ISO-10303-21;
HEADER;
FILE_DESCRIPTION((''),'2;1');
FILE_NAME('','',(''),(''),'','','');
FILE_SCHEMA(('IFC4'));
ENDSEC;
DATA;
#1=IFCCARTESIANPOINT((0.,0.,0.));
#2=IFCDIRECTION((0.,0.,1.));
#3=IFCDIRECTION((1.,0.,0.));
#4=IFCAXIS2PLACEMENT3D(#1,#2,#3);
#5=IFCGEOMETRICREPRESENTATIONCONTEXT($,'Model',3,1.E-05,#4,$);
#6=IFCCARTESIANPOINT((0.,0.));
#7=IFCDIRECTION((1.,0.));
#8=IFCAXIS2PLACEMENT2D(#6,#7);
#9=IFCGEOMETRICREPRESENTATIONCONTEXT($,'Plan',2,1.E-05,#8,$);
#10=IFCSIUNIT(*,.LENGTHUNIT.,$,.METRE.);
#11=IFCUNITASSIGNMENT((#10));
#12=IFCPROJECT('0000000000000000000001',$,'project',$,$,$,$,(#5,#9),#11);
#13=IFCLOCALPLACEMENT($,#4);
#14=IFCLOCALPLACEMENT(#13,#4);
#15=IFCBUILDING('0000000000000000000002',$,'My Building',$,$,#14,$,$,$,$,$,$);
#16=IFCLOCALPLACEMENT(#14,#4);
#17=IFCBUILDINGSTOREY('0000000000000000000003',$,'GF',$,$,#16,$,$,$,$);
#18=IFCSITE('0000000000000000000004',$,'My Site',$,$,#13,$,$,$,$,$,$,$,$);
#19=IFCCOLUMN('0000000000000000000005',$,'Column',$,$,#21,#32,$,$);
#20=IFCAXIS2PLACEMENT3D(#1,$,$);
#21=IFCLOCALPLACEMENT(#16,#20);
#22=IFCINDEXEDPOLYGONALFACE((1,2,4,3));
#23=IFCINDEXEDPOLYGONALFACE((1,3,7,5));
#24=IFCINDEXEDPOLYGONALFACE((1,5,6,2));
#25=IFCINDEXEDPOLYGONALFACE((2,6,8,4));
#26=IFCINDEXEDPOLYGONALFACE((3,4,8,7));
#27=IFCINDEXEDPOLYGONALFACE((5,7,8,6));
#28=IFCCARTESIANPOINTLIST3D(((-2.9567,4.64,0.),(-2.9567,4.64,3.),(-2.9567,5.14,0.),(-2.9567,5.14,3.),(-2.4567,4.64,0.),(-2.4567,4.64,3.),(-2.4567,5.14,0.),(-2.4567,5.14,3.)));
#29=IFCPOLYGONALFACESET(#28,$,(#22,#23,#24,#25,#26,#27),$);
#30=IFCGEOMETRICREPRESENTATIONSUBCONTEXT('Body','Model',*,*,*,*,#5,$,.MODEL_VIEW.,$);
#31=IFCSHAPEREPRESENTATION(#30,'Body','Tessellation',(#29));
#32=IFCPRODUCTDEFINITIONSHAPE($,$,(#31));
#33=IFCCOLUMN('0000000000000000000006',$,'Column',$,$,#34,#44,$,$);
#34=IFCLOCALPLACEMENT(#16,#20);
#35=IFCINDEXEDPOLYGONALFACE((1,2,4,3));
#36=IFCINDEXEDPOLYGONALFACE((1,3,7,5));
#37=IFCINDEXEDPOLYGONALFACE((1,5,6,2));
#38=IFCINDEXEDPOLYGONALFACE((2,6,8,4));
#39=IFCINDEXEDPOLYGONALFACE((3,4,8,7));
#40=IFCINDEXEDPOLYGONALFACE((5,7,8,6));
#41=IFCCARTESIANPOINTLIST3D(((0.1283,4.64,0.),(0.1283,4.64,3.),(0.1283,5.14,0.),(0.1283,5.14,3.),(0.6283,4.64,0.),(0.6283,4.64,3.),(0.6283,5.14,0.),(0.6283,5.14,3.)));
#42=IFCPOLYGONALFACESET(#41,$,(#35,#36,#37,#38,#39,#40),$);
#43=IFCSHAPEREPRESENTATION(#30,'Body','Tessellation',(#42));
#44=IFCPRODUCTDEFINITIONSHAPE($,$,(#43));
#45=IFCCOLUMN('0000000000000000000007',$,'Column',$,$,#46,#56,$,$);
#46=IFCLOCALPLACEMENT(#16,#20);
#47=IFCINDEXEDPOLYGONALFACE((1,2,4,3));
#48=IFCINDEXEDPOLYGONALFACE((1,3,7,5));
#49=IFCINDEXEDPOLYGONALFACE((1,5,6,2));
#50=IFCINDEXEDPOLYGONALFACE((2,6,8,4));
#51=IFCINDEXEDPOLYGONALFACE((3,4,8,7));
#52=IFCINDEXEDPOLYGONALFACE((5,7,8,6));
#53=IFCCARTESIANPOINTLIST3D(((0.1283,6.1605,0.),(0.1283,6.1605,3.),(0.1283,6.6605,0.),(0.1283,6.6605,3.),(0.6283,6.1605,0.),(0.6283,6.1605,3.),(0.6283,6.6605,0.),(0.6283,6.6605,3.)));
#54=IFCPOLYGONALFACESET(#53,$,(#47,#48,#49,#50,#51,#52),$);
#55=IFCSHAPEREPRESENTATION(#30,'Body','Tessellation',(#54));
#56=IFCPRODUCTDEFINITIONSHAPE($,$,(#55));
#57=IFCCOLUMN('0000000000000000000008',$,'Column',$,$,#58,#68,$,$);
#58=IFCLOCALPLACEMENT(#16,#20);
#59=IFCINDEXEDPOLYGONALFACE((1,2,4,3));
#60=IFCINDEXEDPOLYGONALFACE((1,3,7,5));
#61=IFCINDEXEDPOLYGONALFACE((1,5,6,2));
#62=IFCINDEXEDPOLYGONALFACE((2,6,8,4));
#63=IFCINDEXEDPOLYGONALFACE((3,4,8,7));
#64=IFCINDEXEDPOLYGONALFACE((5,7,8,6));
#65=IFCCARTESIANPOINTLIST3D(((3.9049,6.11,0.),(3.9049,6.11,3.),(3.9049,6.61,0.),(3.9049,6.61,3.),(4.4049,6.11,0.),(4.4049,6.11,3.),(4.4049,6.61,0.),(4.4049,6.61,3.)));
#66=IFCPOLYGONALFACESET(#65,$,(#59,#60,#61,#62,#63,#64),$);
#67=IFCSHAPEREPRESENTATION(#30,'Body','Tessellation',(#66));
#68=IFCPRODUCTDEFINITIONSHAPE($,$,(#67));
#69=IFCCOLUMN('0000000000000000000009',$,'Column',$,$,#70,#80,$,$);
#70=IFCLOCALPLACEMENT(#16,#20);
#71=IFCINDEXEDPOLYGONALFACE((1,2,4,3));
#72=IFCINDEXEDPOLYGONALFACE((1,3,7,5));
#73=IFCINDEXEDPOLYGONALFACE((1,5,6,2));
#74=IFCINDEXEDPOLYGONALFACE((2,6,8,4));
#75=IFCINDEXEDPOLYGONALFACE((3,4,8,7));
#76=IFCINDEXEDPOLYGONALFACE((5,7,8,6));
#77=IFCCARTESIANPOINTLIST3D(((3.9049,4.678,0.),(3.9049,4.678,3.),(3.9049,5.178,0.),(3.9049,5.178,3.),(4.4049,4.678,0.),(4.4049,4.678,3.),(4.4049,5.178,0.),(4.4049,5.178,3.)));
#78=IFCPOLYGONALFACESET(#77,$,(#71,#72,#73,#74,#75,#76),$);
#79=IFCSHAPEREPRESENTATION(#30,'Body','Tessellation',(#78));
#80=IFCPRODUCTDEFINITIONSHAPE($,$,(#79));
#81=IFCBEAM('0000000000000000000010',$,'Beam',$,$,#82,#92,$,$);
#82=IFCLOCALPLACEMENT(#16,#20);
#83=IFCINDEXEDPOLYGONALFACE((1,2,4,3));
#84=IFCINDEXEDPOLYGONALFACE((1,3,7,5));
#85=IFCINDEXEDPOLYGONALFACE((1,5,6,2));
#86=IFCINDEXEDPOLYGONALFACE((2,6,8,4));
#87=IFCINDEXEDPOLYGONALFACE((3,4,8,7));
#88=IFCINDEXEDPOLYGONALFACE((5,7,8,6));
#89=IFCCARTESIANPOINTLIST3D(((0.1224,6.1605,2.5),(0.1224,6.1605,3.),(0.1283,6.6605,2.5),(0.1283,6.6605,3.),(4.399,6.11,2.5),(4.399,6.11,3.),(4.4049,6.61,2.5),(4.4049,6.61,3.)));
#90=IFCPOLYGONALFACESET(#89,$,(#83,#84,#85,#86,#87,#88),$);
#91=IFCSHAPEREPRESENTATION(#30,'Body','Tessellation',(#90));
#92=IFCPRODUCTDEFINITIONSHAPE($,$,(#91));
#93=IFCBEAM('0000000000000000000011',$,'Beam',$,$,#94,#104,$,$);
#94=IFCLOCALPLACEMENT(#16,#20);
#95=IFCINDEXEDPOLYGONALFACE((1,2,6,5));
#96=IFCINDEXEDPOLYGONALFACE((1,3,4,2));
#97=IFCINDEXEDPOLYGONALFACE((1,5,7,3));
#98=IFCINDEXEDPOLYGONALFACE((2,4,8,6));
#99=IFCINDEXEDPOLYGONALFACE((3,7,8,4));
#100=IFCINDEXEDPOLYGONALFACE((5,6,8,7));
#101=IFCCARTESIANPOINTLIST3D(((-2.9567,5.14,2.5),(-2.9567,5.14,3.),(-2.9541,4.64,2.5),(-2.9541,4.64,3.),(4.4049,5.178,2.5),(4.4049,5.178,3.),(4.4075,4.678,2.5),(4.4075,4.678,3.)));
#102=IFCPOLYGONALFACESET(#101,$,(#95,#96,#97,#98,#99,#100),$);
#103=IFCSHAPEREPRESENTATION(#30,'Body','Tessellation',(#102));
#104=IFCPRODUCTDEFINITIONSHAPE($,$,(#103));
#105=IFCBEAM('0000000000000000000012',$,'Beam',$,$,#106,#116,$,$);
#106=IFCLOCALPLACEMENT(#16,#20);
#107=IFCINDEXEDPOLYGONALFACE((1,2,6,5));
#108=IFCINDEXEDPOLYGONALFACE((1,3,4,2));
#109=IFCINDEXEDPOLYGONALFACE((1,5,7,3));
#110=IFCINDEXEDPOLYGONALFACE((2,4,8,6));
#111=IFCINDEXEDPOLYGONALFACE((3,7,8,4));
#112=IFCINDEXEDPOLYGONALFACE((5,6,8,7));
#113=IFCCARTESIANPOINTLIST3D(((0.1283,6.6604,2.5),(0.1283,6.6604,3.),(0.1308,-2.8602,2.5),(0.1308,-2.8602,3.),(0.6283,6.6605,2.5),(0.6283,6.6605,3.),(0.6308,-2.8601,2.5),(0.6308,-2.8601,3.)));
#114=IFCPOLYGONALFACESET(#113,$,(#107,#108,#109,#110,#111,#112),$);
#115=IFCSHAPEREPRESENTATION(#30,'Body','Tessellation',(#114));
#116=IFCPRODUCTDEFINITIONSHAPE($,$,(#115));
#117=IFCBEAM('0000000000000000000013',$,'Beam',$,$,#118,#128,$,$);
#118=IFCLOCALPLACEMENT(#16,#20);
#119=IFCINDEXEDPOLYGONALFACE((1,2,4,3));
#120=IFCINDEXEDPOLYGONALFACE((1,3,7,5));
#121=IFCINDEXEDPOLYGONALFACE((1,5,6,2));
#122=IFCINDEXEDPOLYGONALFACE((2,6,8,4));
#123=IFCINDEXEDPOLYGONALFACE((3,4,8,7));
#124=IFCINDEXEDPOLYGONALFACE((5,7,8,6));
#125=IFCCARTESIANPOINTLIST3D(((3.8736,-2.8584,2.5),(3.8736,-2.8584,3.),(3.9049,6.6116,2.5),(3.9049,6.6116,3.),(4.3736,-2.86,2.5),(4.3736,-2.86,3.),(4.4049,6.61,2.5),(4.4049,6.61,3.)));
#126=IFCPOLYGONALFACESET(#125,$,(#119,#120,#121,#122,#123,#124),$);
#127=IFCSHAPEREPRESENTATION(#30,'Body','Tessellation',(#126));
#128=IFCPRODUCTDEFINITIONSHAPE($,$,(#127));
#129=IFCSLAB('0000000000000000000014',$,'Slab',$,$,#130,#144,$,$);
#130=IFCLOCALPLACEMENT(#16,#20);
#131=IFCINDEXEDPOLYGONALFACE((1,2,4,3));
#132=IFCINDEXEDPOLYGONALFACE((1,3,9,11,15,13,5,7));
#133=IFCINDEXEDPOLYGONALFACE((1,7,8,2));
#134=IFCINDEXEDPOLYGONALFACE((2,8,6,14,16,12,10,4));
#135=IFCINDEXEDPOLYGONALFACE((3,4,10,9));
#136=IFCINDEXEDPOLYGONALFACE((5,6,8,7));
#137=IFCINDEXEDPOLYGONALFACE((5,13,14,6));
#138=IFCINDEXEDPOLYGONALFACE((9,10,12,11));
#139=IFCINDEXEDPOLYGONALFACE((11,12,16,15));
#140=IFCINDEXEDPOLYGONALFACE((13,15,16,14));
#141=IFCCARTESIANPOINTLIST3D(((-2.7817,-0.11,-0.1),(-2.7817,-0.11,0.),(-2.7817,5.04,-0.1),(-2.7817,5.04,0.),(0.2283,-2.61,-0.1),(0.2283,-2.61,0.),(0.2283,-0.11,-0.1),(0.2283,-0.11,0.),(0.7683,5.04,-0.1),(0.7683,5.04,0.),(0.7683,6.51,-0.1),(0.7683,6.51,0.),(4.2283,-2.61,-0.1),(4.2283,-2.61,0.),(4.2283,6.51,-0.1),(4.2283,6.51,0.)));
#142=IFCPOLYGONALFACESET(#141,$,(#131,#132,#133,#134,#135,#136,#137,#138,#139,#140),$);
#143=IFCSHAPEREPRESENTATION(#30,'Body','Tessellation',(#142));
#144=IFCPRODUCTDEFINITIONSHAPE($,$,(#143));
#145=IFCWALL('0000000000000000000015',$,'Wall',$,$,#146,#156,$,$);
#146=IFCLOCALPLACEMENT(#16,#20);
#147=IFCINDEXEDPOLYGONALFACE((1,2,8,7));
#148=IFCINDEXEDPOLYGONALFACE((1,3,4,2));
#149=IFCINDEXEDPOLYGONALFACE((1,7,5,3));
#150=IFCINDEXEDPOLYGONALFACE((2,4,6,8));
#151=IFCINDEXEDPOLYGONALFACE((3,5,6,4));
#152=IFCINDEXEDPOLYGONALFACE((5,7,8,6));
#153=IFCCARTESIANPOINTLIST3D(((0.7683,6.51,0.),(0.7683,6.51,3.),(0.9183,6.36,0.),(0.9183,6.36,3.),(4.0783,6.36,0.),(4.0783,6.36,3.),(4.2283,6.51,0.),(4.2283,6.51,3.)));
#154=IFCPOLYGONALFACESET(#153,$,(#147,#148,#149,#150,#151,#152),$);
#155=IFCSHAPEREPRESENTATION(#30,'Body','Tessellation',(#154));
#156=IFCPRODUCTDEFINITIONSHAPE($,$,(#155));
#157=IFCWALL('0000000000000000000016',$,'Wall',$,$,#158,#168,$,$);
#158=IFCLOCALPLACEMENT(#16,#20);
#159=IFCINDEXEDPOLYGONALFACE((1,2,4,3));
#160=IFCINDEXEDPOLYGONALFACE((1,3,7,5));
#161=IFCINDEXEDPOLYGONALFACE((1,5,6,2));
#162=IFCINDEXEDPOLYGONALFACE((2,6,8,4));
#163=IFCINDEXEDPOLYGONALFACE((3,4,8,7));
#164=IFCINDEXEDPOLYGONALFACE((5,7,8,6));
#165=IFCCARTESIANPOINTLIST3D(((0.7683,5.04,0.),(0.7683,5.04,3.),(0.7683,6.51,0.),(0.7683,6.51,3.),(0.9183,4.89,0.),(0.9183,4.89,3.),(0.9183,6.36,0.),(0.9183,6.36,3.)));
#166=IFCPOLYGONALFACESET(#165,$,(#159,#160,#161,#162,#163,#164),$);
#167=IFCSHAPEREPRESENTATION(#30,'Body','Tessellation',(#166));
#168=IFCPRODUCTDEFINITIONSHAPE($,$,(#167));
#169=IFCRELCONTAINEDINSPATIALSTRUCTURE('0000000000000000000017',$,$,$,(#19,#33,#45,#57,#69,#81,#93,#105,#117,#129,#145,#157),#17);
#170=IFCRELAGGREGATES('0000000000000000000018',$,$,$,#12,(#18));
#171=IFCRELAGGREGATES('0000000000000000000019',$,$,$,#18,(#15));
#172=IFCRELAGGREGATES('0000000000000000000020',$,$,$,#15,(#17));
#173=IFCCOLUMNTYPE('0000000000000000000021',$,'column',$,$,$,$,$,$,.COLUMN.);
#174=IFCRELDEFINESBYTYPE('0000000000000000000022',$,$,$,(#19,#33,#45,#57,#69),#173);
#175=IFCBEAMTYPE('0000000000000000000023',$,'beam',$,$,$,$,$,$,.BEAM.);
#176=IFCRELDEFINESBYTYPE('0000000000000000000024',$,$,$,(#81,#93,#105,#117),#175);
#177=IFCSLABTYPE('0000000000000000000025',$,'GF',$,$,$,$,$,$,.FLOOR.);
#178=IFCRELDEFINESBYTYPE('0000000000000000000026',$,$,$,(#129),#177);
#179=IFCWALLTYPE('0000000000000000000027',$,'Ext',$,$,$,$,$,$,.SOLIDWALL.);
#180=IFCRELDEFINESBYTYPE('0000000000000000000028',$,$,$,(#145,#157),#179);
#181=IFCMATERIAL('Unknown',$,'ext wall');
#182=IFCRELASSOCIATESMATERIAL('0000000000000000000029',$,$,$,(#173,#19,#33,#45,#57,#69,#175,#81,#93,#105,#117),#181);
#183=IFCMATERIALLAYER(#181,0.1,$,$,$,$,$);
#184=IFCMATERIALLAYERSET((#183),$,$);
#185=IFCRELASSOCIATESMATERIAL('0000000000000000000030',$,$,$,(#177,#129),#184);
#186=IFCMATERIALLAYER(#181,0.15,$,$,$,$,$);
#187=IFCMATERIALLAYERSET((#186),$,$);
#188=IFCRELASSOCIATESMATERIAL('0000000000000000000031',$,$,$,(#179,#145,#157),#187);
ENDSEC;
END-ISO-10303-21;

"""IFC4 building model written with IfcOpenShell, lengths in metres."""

from ifc_helpers import new_model, si_unit, frame, origin_with_axes, origin_2d_with_axis, place, context, subcontext, project, spatial, line, indexed_curve, rectangle, outline, extrude, material, layer, layer_set, layer_usage, material_profile, profile_set, profile_usage, type_object, element, save


model = new_model("IFC4")

# Units and contexts
model_context = context("Model", 3, precision=1e-05, world=origin_with_axes())
plan_context = context("Plan", 2, precision=1e-05, world=origin_2d_with_axis())
body_context_1 = subcontext(model_context, "Body", "Model", "MODEL_VIEW")
ifc_project = project(units=[si_unit("LENGTHUNIT", "METRE")], contexts=[model_context, plan_context])

# Site, building, storey
site_placement = place(None, origin_with_axes())
site = spatial("IfcSite", under=ifc_project, at=site_placement, Name="My Site")
building_placement = place(site_placement, origin_with_axes())
building = spatial("IfcBuilding", under=site, at=building_placement, Name="My Building")
storey_placement = place(building_placement, origin_with_axes())
storey = spatial("IfcBuildingStorey", under=building, at=storey_placement, Name="GF")

# Columns
ifc_material = material(Name="Unknown", Category="ext wall")
ifc_material_profile_1 = material_profile(ifc_material, rectangle(XDim=0.5, YDim=0.5))
ifc_profile_set_1 = profile_set([ifc_material_profile_1])
ifc_profile_usage_1 = profile_usage(ifc_profile_set_1, cardinal=5)
column_type = type_object("IfcColumnType", Name="column", PredefinedType="COLUMN", material=ifc_profile_set_1)
column_1_placement = place(storey_placement, frame((-2.7067, 4.89, 0.0), z_axis=(0.0, 0.0, 1.0), x_axis=(1.0, 0.0, 0.0)))
element("IfcColumn", 1, at=column_1_placement, inside=storey, type_object=column_type, material=ifc_profile_usage_1, Name="Column", context=body_context_1, shape_type="SweptSolid", body=[
    extrude(rectangle(XDim=0.5, YDim=0.5), origin_with_axes(), (0.0, 0.0, 1.0), 3.0),
])
ifc_profile_usage_2 = profile_usage(ifc_profile_set_1, cardinal=5)
column_2_placement = place(storey_placement, frame((0.3783, 4.89, 0.0), z_axis=(0.0, 0.0, 1.0), x_axis=(1.0, 0.0, 0.0)))
element("IfcColumn", 2, at=column_2_placement, inside=storey, type_object=column_type, material=ifc_profile_usage_2, Name="Column", context=body_context_1, shape_type="SweptSolid", body=[
    extrude(rectangle(XDim=0.5, YDim=0.5), origin_with_axes(), (0.0, 0.0, 1.0), 3.0),
])
ifc_profile_usage_3 = profile_usage(ifc_profile_set_1, cardinal=5)
column_3_placement = place(storey_placement, frame((0.3783, 6.4105, 0.0), z_axis=(0.0, 0.0, 1.0), x_axis=(1.0, 0.0, 0.0)))
element("IfcColumn", 3, at=column_3_placement, inside=storey, type_object=column_type, material=ifc_profile_usage_3, Name="Column", context=body_context_1, shape_type="SweptSolid", body=[
    extrude(rectangle(XDim=0.5, YDim=0.5), origin_with_axes(), (0.0, 0.0, 1.0), 3.0),
])
ifc_profile_usage_4 = profile_usage(ifc_profile_set_1, cardinal=5)
column_4_placement = place(storey_placement, frame((4.1549, 6.36, 0.0), z_axis=(0.0, 0.0, 1.0), x_axis=(1.0, 0.0, 0.0)))
element("IfcColumn", 4, at=column_4_placement, inside=storey, type_object=column_type, material=ifc_profile_usage_4, Name="Column", context=body_context_1, shape_type="SweptSolid", body=[
    extrude(rectangle(XDim=0.5, YDim=0.5), origin_with_axes(), (0.0, 0.0, 1.0), 3.0),
])
ifc_profile_usage_5 = profile_usage(ifc_profile_set_1, cardinal=5)
column_5_placement = place(storey_placement, frame((4.1549, 4.928, 0.0), z_axis=(0.0, 0.0, 1.0), x_axis=(1.0, 0.0, 0.0)))
element("IfcColumn", 5, at=column_5_placement, inside=storey, type_object=column_type, material=ifc_profile_usage_5, Name="Column", context=body_context_1, shape_type="SweptSolid", body=[
    extrude(rectangle(XDim=0.5, YDim=0.5), origin_with_axes(), (0.0, 0.0, 1.0), 3.0),
])

# Beams
ifc_material_profile_2 = material_profile(ifc_material, rectangle(XDim=0.5, YDim=0.5))
ifc_profile_set_2 = profile_set([ifc_material_profile_2])
ifc_profile_usage_6 = profile_usage(ifc_profile_set_2, cardinal=7)
beam_type = type_object("IfcBeamType", Name="beam", PredefinedType="BEAM", material=ifc_profile_set_2)
beam_1_placement = place(storey_placement, frame((0.1283, 6.6605, 3.0), z_axis=(0.99993, -0.011816, 0.0), x_axis=(0.011816, 0.99993, 0.0)))
element("IfcBeam", 6, at=beam_1_placement, inside=storey, type_object=beam_type, material=ifc_profile_usage_6, Name="Beam", context=body_context_1, shape_type="SweptSolid", body=[
    extrude(rectangle(XDim=0.5, YDim=0.5), frame((-0.25, -0.25, 0.0), z_axis=(0.0, 0.0, 1.0), x_axis=(1.0, 0.0, 0.0)), (0.0, 0.0, 1.0), 4.2769),
])
ifc_profile_usage_7 = profile_usage(ifc_profile_set_2, cardinal=7)
beam_2_placement = place(storey_placement, frame((-2.9567, 5.14, 3.0), z_axis=(0.999987, 0.005166, 0.0), x_axis=(-0.005166, 0.999987, 0.0)))
element("IfcBeam", 7, at=beam_2_placement, inside=storey, type_object=beam_type, material=ifc_profile_usage_7, Name="Beam", context=body_context_1, shape_type="SweptSolid", body=[
    extrude(rectangle(XDim=0.5, YDim=0.5), frame((-0.25, -0.25, 0.0), z_axis=(0.0, 0.0, 1.0), x_axis=(1.0, 0.0, 0.0)), (0.0, 0.0, 1.0), 7.3617),
])
ifc_profile_usage_8 = profile_usage(ifc_profile_set_2, cardinal=7)
beam_3_placement = place(storey_placement, frame((0.6283, 6.6605, 3.0), z_axis=(0.000261, -1.0, 0.0), x_axis=(1.0, 0.000261, 0.0)))
element("IfcBeam", 8, at=beam_3_placement, inside=storey, type_object=beam_type, material=ifc_profile_usage_8, Name="Beam", context=body_context_1, shape_type="SweptSolid", body=[
    extrude(rectangle(XDim=0.5, YDim=0.5), frame((-0.25, -0.25, 0.0), z_axis=(0.0, 0.0, 1.0), x_axis=(1.0, 0.0, 0.0)), (0.0, 0.0, 1.0), 9.5206),
])
ifc_profile_usage_9 = profile_usage(ifc_profile_set_2, cardinal=7)
beam_4_placement = place(storey_placement, frame((4.4049, 6.61, 3.0), z_axis=(-0.003306, -0.999995, 0.0), x_axis=(0.999995, -0.003306, 0.0)))
element("IfcBeam", 9, at=beam_4_placement, inside=storey, type_object=beam_type, material=ifc_profile_usage_9, Name="Beam", context=body_context_1, shape_type="SweptSolid", body=[
    extrude(rectangle(XDim=0.5, YDim=0.5), frame((-0.25, -0.25, 0.0), z_axis=(0.0, 0.0, 1.0), x_axis=(1.0, 0.0, 0.0)), (0.0, 0.0, 1.0), 9.4701),
])

# Slab
ifc_layer_1 = layer(ifc_material, 0.1)
ifc_layer_set_1 = layer_set([ifc_layer_1])
ifc_layer_usage_1 = layer_usage(ifc_layer_set_1, "AXIS3", "POSITIVE", -0.1)
slab_type = type_object("IfcSlabType", Name="GF", PredefinedType="FLOOR", material=ifc_layer_set_1)
slab_placement = place(storey_placement, frame((-2.7817, 5.04, 0.0), z_axis=(0.0, 0.0, 1.0), x_axis=(1.0, 0.0, 0.0)))
element("IfcSlab", 10, at=slab_placement, inside=storey, type_object=slab_type, material=ifc_layer_usage_1, Name="Slab", context=body_context_1, shape_type="SweptSolid", body=[
    extrude(outline(indexed_curve([(0.0, 0.0), (3.55, 0.0), (3.55, 1.47), (7.01, 1.47), (7.01, -7.65), (3.01, -7.65), (3.01, -5.15), (0.0, -5.15), (0.0, 0.0)])), frame((0.0, 0.0, -0.1), z_axis=(0.0, 0.0, 1.0), x_axis=(1.0, 0.0, 0.0)), (0.0, 0.0, 1.0), 0.1),
])

# Walls
ifc_layer_2 = layer(ifc_material, 0.15)
ifc_layer_set_2 = layer_set([ifc_layer_2])
ifc_layer_usage_2 = layer_usage(ifc_layer_set_2, "AXIS2", "POSITIVE", 0.0)
wall_type_1 = type_object("IfcWallType", Name="Ext", PredefinedType="SOLIDWALL", material=ifc_layer_set_2)
wall_1_placement = place(storey_placement, frame((4.2283, 6.51, 0.0), z_axis=(0.0, 0.0, 1.0), x_axis=(-1.0, 0.0, 0.0)))
element("IfcWall", 11, at=wall_1_placement, inside=storey, type_object=wall_type_1, material=ifc_layer_usage_2, Name="Wall", context=body_context_1, shape_type="SweptSolid", body=[
    extrude(outline(indexed_curve([(0.0, 0.0), (0.15, 0.15), (3.31, 0.15), (3.46, 0.0)], segments=[line(1, 2, 3, 4, 1)])), origin_with_axes(), (0.0, 0.0, 1.0), 3.0),
])
ifc_layer_usage_3 = layer_usage(ifc_layer_set_2, "AXIS2", "POSITIVE", 0.0)
wall_2_placement = place(storey_placement, frame((0.7683, 6.51, 0.0), z_axis=(0.0, 0.0, 1.0), x_axis=(0.0, -1.0, 0.0)))
element("IfcWall", 12, at=wall_2_placement, inside=storey, type_object=wall_type_1, material=ifc_layer_usage_3, Name="Wall", context=body_context_1, shape_type="SweptSolid", body=[
    extrude(outline(indexed_curve([(0.0, 0.0), (0.15, 0.15), (1.62, 0.15), (1.47, 0.0)], segments=[line(1, 2, 3, 4, 1)])), origin_with_axes(), (0.0, 0.0, 1.0), 3.0),
])

save(model, "model.ifc")
